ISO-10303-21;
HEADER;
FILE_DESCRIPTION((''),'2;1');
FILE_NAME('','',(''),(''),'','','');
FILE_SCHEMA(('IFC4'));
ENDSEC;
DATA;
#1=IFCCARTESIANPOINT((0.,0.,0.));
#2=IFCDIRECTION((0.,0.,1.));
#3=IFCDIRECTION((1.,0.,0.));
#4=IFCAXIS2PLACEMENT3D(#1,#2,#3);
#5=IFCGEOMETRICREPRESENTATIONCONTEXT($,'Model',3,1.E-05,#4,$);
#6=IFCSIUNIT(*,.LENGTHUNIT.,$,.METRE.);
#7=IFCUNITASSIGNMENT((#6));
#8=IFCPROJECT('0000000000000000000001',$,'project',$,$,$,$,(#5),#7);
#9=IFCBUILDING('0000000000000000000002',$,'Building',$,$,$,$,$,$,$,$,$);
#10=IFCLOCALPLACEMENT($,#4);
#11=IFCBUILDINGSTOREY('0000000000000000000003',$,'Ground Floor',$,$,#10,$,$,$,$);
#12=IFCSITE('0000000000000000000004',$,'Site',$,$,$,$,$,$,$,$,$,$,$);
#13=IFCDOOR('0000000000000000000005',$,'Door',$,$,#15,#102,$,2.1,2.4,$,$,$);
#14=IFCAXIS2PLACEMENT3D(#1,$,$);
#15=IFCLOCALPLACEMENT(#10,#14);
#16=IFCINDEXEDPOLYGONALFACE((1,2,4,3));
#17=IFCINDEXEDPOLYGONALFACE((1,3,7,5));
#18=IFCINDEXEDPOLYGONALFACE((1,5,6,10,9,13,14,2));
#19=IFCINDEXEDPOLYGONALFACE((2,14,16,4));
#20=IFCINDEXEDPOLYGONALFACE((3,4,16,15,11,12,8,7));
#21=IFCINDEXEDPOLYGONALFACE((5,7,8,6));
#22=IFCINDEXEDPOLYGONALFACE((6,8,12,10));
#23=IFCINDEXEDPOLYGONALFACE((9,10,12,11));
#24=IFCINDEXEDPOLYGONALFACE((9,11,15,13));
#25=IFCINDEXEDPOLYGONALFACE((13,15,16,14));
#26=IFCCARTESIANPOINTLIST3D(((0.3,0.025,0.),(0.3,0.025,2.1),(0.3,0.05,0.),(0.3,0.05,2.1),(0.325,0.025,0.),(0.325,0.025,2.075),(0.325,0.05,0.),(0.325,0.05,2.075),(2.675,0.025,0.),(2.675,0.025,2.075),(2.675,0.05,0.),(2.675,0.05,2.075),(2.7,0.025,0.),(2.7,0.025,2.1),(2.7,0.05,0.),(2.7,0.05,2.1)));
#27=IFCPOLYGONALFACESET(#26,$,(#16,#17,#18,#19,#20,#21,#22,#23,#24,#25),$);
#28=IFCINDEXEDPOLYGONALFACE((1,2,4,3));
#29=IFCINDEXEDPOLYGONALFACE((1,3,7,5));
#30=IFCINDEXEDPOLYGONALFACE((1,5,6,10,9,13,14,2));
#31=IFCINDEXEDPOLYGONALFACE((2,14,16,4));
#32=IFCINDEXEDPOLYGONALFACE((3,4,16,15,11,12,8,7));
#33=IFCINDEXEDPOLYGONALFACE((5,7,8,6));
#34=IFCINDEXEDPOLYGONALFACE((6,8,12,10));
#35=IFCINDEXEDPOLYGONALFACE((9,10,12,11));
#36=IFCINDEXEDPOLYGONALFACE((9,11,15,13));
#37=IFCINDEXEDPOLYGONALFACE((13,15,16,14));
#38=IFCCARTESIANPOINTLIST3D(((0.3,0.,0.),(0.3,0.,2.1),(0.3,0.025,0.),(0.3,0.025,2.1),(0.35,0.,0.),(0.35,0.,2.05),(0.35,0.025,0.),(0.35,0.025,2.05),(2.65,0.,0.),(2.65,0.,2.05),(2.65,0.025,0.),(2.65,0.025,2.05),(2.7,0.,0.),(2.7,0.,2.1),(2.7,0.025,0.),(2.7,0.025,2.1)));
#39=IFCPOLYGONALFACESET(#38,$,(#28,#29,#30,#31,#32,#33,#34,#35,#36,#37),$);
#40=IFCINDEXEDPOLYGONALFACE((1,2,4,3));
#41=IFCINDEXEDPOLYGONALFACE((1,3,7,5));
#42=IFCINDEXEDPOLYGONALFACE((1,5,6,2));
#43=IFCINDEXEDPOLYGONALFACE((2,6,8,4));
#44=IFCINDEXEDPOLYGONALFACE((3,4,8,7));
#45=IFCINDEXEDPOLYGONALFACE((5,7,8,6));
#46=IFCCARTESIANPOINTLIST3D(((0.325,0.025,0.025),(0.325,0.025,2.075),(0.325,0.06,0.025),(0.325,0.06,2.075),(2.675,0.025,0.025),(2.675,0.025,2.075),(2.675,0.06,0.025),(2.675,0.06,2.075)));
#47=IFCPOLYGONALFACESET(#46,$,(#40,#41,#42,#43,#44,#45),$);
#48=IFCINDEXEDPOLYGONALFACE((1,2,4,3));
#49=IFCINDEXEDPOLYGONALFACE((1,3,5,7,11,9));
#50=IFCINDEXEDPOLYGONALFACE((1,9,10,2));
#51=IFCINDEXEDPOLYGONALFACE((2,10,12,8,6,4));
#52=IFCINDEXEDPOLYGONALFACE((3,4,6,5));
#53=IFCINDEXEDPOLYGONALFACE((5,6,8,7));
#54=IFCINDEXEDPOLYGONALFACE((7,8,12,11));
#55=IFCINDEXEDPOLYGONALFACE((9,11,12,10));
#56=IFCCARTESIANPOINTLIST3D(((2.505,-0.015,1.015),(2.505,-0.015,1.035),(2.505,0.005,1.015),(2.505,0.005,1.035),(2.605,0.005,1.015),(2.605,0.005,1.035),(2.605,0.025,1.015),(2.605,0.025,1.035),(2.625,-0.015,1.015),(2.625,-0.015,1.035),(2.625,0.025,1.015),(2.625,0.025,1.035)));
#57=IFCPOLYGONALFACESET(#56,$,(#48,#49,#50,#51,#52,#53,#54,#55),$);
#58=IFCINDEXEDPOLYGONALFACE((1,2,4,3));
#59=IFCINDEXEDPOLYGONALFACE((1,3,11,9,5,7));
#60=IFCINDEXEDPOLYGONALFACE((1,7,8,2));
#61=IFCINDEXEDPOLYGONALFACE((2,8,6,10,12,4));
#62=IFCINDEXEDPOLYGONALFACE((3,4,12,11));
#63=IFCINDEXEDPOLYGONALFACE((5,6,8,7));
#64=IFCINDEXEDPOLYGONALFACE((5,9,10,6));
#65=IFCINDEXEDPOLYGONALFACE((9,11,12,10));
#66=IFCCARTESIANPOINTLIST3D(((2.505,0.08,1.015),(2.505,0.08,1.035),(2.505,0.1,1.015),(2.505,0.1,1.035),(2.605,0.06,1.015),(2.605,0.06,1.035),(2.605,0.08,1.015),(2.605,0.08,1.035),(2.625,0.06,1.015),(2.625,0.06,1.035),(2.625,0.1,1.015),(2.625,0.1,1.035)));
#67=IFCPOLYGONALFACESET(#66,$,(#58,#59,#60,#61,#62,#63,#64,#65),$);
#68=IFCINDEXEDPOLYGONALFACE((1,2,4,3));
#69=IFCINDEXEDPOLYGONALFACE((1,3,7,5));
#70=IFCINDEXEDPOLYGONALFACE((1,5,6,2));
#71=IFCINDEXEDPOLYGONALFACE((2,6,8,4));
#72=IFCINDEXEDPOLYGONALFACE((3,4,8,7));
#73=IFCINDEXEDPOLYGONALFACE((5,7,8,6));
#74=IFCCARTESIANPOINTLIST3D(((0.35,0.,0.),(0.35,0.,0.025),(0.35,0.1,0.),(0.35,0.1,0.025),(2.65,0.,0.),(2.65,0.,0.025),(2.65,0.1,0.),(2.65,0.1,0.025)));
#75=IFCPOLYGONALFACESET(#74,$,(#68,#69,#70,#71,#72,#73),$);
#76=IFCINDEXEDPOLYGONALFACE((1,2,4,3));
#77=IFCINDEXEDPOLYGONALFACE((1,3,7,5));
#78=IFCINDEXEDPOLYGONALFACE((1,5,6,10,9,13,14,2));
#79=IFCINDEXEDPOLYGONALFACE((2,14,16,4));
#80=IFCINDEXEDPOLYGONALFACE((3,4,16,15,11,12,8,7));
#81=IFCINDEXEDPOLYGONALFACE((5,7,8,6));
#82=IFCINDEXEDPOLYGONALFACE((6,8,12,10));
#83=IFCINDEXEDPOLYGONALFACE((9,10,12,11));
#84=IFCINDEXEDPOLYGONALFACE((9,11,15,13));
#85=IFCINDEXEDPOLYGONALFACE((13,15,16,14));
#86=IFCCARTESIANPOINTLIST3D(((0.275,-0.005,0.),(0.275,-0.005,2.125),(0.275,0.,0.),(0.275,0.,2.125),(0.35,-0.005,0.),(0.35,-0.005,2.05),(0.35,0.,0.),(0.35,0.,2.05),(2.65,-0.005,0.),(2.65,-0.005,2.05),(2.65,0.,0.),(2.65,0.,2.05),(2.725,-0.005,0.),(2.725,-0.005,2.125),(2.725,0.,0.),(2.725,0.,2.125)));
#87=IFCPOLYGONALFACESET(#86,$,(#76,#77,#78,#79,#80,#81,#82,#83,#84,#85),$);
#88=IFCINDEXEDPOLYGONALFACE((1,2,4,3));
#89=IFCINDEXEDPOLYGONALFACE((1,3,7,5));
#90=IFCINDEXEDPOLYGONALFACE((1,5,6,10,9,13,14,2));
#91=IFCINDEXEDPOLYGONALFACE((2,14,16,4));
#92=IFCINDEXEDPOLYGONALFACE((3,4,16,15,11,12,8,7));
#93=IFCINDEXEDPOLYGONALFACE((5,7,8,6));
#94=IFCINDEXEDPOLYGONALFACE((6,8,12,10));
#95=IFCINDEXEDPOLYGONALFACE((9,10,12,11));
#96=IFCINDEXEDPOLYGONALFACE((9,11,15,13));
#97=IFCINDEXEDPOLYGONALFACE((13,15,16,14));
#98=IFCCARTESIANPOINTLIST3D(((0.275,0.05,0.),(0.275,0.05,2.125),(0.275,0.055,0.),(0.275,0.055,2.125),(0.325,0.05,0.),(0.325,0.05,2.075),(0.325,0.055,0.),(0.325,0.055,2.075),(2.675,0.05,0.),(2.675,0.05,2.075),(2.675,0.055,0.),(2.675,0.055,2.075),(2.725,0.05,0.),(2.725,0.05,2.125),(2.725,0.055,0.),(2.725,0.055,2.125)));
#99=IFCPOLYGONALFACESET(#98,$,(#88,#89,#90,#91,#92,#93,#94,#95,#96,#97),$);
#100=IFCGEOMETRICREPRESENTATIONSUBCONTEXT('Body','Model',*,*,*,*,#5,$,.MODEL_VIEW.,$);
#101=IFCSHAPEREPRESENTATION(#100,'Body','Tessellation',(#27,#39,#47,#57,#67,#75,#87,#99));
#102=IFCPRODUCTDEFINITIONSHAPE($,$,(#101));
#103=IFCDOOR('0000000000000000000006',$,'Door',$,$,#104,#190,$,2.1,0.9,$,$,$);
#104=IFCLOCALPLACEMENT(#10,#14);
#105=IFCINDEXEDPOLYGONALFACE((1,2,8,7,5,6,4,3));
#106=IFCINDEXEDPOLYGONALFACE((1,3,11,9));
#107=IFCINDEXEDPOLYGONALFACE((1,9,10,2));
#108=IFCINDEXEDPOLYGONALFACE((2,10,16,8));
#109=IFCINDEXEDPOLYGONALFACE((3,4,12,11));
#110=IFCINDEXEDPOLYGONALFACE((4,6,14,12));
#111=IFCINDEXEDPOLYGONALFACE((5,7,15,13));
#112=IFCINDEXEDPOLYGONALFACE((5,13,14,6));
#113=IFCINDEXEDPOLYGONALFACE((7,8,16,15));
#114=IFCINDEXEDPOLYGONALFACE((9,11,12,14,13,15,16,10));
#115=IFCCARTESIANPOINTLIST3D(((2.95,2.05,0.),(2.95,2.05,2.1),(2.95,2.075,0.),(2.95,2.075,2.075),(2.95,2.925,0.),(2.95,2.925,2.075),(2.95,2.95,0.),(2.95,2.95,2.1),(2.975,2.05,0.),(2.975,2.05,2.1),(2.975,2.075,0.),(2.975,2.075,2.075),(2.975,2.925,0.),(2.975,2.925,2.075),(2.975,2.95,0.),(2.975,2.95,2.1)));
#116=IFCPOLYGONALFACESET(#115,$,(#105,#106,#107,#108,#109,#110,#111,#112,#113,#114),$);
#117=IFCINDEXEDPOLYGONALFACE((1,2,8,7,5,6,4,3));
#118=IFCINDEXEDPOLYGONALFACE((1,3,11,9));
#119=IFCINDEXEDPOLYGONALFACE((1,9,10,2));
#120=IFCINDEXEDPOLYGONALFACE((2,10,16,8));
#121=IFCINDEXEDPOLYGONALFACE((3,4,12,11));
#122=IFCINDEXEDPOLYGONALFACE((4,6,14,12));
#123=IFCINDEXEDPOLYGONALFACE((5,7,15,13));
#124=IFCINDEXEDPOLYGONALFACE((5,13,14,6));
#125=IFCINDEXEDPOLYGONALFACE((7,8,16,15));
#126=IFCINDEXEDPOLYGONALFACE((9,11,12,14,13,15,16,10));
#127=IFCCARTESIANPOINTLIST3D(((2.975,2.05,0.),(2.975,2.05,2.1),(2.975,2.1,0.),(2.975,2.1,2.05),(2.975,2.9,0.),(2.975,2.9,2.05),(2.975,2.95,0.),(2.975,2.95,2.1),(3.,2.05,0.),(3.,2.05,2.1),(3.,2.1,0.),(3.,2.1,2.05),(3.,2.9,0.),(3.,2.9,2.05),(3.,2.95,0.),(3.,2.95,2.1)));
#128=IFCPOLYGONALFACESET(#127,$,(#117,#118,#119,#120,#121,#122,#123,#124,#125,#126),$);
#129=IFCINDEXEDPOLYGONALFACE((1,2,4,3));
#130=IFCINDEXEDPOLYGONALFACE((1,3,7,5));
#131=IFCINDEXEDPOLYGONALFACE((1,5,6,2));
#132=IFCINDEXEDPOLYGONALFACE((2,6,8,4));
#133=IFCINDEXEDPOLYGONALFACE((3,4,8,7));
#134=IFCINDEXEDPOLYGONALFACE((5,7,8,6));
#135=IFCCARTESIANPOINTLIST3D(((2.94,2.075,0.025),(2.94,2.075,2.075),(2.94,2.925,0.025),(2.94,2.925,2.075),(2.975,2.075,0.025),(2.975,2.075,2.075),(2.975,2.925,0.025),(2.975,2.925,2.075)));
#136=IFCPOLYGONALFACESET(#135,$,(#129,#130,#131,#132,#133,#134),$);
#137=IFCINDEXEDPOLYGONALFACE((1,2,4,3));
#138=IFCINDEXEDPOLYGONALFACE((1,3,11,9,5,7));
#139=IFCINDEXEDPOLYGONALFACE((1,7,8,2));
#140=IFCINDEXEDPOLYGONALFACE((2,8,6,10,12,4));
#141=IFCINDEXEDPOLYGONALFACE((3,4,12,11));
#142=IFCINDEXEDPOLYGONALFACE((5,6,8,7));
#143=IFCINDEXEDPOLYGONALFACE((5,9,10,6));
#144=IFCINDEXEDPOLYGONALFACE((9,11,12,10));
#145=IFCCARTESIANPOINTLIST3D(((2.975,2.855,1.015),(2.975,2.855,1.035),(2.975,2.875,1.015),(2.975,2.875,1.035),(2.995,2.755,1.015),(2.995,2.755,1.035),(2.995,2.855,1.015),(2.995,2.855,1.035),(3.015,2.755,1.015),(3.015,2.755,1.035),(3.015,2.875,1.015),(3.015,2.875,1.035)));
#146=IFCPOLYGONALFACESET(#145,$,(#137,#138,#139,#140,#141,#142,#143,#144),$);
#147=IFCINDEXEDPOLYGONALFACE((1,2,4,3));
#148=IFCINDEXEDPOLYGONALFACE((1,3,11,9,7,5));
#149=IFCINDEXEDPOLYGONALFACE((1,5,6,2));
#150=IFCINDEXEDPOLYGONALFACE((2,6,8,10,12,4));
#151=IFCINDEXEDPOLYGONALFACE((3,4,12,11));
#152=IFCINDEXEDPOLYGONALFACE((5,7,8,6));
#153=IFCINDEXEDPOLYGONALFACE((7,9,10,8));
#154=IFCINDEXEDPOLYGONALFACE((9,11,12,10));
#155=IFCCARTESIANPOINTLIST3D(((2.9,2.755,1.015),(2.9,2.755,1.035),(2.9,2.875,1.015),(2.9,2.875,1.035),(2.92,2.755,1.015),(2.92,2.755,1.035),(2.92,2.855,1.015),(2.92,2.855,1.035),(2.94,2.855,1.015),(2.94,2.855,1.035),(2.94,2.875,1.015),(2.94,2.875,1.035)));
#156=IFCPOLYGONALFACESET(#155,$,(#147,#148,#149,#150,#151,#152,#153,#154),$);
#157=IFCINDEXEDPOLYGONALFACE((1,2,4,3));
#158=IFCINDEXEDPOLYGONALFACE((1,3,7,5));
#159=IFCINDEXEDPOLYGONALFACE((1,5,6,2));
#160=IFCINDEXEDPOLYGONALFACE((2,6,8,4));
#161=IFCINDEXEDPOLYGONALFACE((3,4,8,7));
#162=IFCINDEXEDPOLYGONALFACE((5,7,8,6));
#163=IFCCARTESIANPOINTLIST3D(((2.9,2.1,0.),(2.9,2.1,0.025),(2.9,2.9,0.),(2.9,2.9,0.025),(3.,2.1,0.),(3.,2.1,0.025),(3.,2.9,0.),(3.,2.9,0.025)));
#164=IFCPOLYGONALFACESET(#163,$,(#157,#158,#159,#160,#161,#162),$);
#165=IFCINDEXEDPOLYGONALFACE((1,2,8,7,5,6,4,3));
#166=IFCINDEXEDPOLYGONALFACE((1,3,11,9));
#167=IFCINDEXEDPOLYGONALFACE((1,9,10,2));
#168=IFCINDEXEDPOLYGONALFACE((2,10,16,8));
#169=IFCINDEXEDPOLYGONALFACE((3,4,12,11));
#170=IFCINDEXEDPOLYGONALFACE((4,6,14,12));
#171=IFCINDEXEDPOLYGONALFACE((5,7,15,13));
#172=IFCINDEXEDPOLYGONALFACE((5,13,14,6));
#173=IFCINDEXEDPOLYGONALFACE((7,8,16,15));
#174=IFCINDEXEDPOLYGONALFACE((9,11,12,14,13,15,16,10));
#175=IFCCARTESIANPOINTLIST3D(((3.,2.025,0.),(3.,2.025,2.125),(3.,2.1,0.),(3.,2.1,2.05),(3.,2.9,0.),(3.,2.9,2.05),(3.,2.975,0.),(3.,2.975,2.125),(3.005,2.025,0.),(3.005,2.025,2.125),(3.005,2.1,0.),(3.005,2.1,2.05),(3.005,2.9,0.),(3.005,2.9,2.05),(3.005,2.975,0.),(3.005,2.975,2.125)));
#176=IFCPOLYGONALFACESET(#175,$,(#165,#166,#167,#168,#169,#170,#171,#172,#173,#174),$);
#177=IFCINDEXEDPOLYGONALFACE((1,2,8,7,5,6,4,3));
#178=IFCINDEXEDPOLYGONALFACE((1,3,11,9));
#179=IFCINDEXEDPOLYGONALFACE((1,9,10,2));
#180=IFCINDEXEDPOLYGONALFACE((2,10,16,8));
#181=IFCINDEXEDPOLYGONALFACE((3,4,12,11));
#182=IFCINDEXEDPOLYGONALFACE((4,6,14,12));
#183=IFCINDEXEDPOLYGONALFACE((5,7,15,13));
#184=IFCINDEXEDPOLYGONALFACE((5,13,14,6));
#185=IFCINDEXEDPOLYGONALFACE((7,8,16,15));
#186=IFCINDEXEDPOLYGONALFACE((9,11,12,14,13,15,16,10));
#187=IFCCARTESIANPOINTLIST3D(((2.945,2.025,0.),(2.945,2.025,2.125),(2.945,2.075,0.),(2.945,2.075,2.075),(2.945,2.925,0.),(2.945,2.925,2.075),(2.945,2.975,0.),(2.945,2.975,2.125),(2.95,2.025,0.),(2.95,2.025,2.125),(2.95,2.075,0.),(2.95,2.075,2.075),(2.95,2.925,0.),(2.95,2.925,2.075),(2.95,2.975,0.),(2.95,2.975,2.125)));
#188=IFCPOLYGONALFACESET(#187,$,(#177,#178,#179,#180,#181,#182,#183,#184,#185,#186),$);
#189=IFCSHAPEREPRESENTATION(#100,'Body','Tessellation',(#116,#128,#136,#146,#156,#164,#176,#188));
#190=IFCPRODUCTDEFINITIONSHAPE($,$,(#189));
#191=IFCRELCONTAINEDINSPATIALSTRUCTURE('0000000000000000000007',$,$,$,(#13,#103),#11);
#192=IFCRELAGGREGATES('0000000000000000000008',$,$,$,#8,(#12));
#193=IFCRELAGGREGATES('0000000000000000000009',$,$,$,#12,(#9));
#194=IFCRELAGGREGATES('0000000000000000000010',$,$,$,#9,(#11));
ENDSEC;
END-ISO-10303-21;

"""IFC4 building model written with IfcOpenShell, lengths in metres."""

from ifc_helpers import new_model, si_unit, frame, origin_with_axes, place, context, subcontext, project, spatial, line, indexed_curve, outline, extrude, element, save


model = new_model("IFC4")

# Units and contexts
model_context = context("Model", 3, precision=1e-05, world=origin_with_axes())
body_context = subcontext(model_context, "Body", "Model", "MODEL_VIEW")
ifc_project = project(units=[si_unit("LENGTHUNIT", "METRE")], contexts=[model_context])

# Site, building, storey
site = spatial("IfcSite", under=ifc_project, Name="Site")
building = spatial("IfcBuilding", under=site, Name="Building")
storey_placement = place(None, origin_with_axes())
storey = spatial("IfcBuildingStorey", under=building, at=storey_placement, Name="Ground Floor")

# Doors
door_1_placement = place(storey_placement, frame((0.3, 0.0, 0.0), z_axis=(0.0, 0.0, 1.0), x_axis=(1.0, 0.0, 0.0)))
element("IfcDoor", 1, at=door_1_placement, inside=storey, Name="Door", OverallHeight=2.1, OverallWidth=2.4, context=body_context, shape_type="SweptSolid", body=[
    extrude(outline(indexed_curve([(0.0, 0.0), (0.0, 2.1), (2.4, 2.1), (2.4, 0.0), (2.375, 0.0), (2.375, 2.075), (0.025, 2.075), (0.025, 0.0)], segments=[line(1, 2, 3, 4, 5, 6, 7, 8, 1)])), frame((0.0, 0.025, 0.0), z_axis=(0.0, -1.0, 0.0), x_axis=(1.0, 0.0, 0.0)), (0.0, 0.0, -1.0), 0.025),
    extrude(outline(indexed_curve([(0.0, 0.0), (0.0, 2.1), (2.4, 2.1), (2.4, 0.0), (2.35, 0.0), (2.35, 2.05), (0.05, 2.05), (0.05, 0.0)], segments=[line(1, 2, 3, 4, 5, 6, 7, 8, 1)])), frame((0.0, 0.0, 0.0), z_axis=(0.0, -1.0, 0.0), x_axis=(1.0, 0.0, 0.0)), (0.0, 0.0, -1.0), 0.025),
    extrude(outline(indexed_curve([(0.0, 0.0), (2.35, 0.0), (2.35, 0.035), (0.0, 0.035)], segments=[line(1, 2, 3, 4, 1)])), frame((0.025, 0.025, 0.025), z_axis=(0.0, 0.0, 1.0), x_axis=(1.0, 0.0, 0.0)), (0.0, 0.0, 1.0), 2.05),
    extrude(outline(indexed_curve([(0.0, 0.0), (0.0, -0.04), (-0.12, -0.04), (-0.12, -0.02), (-0.02, -0.02), (-0.02, 0.0)], segments=[line(1, 2, 3, 4, 5, 6, 1)])), frame((2.325, 0.025, 1.015), z_axis=(0.0, 0.0, 1.0), x_axis=(1.0, 0.0, 0.0)), (0.0, 0.0, 1.0), 0.02),
    extrude(outline(indexed_curve([(0.0, 0.0), (0.0, 0.04), (-0.12, 0.04), (-0.12, 0.02), (-0.02, 0.02), (-0.02, 0.0)], segments=[line(1, 2, 3, 4, 5, 6, 1)])), frame((2.325, 0.06, 1.015), z_axis=(0.0, 0.0, 1.0), x_axis=(1.0, 0.0, 0.0)), (0.0, 0.0, 1.0), 0.02),
    extrude(outline(indexed_curve([(0.0, 0.0), (2.3, 0.0), (2.3, 0.1), (0.0, 0.1)], segments=[line(1, 2, 3, 4, 1)])), frame((0.05, 0.0, 0.0), z_axis=(0.0, 0.0, 1.0), x_axis=(1.0, 0.0, 0.0)), (0.0, 0.0, 1.0), 0.025),
    extrude(outline(indexed_curve([(0.0, 0.0), (0.0, 2.125), (2.45, 2.125), (2.45, 0.0), (2.375, 0.0), (2.375, 2.05), (0.075, 2.05), (0.075, 0.0)], segments=[line(1, 2, 3, 4, 5, 6, 7, 8, 1)])), frame((-0.025, -0.005, 0.0), z_axis=(0.0, -1.0, 0.0), x_axis=(1.0, 0.0, 0.0)), (0.0, 0.0, -1.0), 0.005),
    extrude(outline(indexed_curve([(0.0, 0.0), (0.0, 2.125), (2.45, 2.125), (2.45, 0.0), (2.4, 0.0), (2.4, 2.075), (0.05, 2.075), (0.05, 0.0)], segments=[line(1, 2, 3, 4, 5, 6, 7, 8, 1)])), frame((-0.025, 0.05, 0.0), z_axis=(0.0, -1.0, 0.0), x_axis=(1.0, 0.0, 0.0)), (0.0, 0.0, -1.0), 0.005),
])
door_2_placement = place(storey_placement, frame((3.0, 2.05, 0.0), z_axis=(0.0, 0.0, 1.0), x_axis=(0.0, 1.0, 0.0)))
element("IfcDoor", 2, at=door_2_placement, inside=storey, Name="Door", OverallHeight=2.1, OverallWidth=0.9, context=body_context, shape_type="SweptSolid", body=[
    extrude(outline(indexed_curve([(0.0, 0.0), (0.0, 2.1), (0.9, 2.1), (0.9, 0.0), (0.875, 0.0), (0.875, 2.075), (0.025, 2.075), (0.025, 0.0)], segments=[line(1, 2, 3, 4, 5, 6, 7, 8, 1)])), frame((0.0, 0.025, 0.0), z_axis=(0.0, -1.0, 0.0), x_axis=(1.0, 0.0, 0.0)), (0.0, 0.0, -1.0), 0.025),
    extrude(outline(indexed_curve([(0.0, 0.0), (0.0, 2.1), (0.9, 2.1), (0.9, 0.0), (0.85, 0.0), (0.85, 2.05), (0.05, 2.05), (0.05, 0.0)], segments=[line(1, 2, 3, 4, 5, 6, 7, 8, 1)])), frame((0.0, 0.0, 0.0), z_axis=(0.0, -1.0, 0.0), x_axis=(1.0, 0.0, 0.0)), (0.0, 0.0, -1.0), 0.025),
    extrude(outline(indexed_curve([(0.0, 0.0), (0.85, 0.0), (0.85, 0.035), (0.0, 0.035)], segments=[line(1, 2, 3, 4, 1)])), frame((0.025, 0.025, 0.025), z_axis=(0.0, 0.0, 1.0), x_axis=(1.0, 0.0, 0.0)), (0.0, 0.0, 1.0), 2.05),
    extrude(outline(indexed_curve([(0.0, 0.0), (0.0, -0.04), (-0.12, -0.04), (-0.12, -0.02), (-0.02, -0.02), (-0.02, 0.0)], segments=[line(1, 2, 3, 4, 5, 6, 1)])), frame((0.825, 0.025, 1.015), z_axis=(0.0, 0.0, 1.0), x_axis=(1.0, 0.0, 0.0)), (0.0, 0.0, 1.0), 0.02),
    extrude(outline(indexed_curve([(0.0, 0.0), (0.0, 0.04), (-0.12, 0.04), (-0.12, 0.02), (-0.02, 0.02), (-0.02, 0.0)], segments=[line(1, 2, 3, 4, 5, 6, 1)])), frame((0.825, 0.06, 1.015), z_axis=(0.0, 0.0, 1.0), x_axis=(1.0, 0.0, 0.0)), (0.0, 0.0, 1.0), 0.02),
    extrude(outline(indexed_curve([(0.0, 0.0), (0.8, 0.0), (0.8, 0.1), (0.0, 0.1)], segments=[line(1, 2, 3, 4, 1)])), frame((0.05, 0.0, 0.0), z_axis=(0.0, 0.0, 1.0), x_axis=(1.0, 0.0, 0.0)), (0.0, 0.0, 1.0), 0.025),
    extrude(outline(indexed_curve([(0.0, 0.0), (0.0, 2.125), (0.95, 2.125), (0.95, 0.0), (0.875, 0.0), (0.875, 2.05), (0.075, 2.05), (0.075, 0.0)], segments=[line(1, 2, 3, 4, 5, 6, 7, 8, 1)])), frame((-0.025, -0.005, 0.0), z_axis=(0.0, -1.0, 0.0), x_axis=(1.0, 0.0, 0.0)), (0.0, 0.0, -1.0), 0.005),
    extrude(outline(indexed_curve([(0.0, 0.0), (0.0, 2.125), (0.95, 2.125), (0.95, 0.0), (0.9, 0.0), (0.9, 2.075), (0.05, 2.075), (0.05, 0.0)], segments=[line(1, 2, 3, 4, 5, 6, 7, 8, 1)])), frame((-0.025, 0.05, 0.0), z_axis=(0.0, -1.0, 0.0), x_axis=(1.0, 0.0, 0.0)), (0.0, 0.0, -1.0), 0.005),
])

save(model, "model.ifc")
